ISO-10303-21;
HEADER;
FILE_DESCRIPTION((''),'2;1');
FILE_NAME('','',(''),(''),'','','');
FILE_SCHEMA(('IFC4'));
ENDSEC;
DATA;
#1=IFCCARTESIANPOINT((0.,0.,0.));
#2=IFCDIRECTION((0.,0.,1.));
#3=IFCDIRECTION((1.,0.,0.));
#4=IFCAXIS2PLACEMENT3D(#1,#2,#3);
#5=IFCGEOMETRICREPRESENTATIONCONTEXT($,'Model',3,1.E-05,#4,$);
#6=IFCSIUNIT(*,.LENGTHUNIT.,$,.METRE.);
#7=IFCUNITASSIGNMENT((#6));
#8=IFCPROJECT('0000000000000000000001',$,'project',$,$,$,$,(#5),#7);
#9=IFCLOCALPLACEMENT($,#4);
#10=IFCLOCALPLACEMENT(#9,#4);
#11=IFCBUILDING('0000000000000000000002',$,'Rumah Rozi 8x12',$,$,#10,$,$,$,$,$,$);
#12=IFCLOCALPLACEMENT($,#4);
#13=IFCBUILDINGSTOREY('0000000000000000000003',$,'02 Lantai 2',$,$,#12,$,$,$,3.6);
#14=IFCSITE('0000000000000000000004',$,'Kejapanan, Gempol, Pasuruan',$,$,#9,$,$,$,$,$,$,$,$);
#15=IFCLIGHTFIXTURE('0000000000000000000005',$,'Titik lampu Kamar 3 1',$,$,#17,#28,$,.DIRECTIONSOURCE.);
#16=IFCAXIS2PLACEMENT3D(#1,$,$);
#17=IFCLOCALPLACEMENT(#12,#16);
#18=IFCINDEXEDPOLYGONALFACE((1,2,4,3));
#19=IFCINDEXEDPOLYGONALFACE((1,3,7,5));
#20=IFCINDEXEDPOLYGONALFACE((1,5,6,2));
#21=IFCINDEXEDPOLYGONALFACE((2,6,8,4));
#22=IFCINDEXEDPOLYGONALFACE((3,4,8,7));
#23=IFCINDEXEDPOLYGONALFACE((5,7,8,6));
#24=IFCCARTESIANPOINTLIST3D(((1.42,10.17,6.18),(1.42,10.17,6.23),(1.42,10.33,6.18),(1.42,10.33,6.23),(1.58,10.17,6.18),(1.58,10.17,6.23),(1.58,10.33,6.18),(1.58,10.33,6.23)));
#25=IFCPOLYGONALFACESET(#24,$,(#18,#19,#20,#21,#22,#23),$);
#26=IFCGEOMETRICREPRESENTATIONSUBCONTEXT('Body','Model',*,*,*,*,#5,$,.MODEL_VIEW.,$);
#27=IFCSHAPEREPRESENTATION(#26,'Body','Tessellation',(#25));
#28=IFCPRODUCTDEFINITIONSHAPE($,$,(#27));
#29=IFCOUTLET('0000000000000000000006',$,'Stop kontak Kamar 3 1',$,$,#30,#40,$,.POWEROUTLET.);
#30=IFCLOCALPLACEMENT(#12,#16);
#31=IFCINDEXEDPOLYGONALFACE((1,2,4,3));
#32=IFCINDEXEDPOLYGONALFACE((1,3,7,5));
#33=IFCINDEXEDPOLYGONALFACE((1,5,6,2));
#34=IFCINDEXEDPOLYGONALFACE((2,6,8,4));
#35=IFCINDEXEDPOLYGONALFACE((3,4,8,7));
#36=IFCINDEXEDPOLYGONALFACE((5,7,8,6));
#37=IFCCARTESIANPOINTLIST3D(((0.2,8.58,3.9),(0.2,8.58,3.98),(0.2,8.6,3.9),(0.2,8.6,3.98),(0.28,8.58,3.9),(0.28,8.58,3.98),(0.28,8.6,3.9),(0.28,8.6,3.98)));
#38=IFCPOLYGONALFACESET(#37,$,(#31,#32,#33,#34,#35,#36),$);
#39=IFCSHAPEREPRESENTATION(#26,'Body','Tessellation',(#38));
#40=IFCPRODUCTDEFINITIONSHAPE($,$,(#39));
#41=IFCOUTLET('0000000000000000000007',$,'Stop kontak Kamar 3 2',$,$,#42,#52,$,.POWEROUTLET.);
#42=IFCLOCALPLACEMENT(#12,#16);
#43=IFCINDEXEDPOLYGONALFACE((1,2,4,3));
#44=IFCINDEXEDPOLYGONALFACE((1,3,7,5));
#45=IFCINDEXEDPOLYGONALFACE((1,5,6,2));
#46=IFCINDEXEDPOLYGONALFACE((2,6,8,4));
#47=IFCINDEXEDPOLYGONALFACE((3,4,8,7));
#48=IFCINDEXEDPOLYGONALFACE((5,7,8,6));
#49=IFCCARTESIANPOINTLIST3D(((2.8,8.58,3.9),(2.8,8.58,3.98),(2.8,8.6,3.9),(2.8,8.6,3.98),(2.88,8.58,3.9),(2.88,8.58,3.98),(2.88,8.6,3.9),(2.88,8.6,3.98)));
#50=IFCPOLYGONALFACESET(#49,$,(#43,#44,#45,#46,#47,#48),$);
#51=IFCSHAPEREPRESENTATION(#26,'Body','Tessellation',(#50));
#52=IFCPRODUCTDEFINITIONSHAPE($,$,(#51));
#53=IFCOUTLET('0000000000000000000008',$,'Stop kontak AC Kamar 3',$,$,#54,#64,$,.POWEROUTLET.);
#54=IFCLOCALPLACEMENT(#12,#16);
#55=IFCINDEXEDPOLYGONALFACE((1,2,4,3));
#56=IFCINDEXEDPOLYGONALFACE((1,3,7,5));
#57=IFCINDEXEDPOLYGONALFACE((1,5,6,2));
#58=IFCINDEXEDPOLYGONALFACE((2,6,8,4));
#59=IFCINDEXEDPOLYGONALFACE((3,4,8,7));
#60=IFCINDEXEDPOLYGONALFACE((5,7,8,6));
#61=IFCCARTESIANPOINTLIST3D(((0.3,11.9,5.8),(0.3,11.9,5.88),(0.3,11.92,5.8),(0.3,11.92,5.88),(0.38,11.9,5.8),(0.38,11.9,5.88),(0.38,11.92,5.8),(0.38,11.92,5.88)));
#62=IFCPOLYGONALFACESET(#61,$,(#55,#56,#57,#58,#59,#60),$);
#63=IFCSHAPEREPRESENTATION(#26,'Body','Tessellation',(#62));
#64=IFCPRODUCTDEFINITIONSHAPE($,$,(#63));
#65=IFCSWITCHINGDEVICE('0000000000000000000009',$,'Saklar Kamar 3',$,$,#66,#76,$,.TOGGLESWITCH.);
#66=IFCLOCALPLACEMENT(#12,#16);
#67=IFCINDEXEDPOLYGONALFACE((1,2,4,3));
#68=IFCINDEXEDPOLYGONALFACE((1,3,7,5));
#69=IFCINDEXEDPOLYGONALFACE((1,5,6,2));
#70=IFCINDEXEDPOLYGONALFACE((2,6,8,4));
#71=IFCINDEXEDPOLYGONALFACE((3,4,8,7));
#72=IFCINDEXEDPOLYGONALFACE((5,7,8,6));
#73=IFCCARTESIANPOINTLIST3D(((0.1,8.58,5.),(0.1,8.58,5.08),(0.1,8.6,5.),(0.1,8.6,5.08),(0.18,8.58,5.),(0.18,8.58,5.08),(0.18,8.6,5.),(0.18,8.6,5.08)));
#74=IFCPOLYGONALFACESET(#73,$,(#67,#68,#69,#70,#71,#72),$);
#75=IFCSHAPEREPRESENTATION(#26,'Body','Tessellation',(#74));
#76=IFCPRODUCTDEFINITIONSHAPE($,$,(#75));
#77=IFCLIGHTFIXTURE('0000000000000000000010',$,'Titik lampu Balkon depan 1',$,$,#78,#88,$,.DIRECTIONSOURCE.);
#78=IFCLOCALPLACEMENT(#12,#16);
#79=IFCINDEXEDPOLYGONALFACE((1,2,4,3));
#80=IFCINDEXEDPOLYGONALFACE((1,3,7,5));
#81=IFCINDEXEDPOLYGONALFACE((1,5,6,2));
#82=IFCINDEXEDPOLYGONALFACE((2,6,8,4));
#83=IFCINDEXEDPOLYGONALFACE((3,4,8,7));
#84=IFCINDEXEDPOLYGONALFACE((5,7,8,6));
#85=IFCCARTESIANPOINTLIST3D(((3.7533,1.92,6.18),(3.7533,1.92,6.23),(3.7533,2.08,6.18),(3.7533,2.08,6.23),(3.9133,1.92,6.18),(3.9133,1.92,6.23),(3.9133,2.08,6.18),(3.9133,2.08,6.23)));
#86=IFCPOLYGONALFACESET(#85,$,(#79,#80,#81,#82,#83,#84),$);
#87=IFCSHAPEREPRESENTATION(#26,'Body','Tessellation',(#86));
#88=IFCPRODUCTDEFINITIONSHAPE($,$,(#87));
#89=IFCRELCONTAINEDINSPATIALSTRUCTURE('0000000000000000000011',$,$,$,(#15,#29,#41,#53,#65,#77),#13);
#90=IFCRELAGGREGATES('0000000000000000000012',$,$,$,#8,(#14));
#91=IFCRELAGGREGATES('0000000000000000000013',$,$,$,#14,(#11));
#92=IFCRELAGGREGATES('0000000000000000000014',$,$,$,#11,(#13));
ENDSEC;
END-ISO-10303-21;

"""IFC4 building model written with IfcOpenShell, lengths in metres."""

from ifc_helpers import new_model, si_unit, frame, origin_with_axes, place, context, subcontext, project, spatial, line, indexed_curve, outline, extrude, element, save


model = new_model("IFC4")

# Units and contexts
model_context = context("Model", 3, precision=1e-05, world=origin_with_axes())
body_context = subcontext(model_context, "Body", "Model", "MODEL_VIEW")
ifc_project = project(units=[si_unit("LENGTHUNIT", "METRE")], contexts=[model_context])

# Site, building, storey
site_placement = place(None, origin_with_axes())
site = spatial("IfcSite", under=ifc_project, at=site_placement, Name="Kejapanan, Gempol, Pasuruan")
building_placement = place(site_placement, origin_with_axes())
building = spatial("IfcBuilding", under=site, at=building_placement, Name="Rumah Rozi 8x12")
storey_placement = place(None, origin_with_axes())
storey = spatial("IfcBuildingStorey", under=building, at=storey_placement, Name="02 Lantai 2", Elevation=3.6)

# Light fixture
light_fixture_1_placement = place(storey_placement, origin_with_axes())
element("IfcLightFixture", 1, at=light_fixture_1_placement, inside=storey, Name="Titik lampu Kamar 3 1", PredefinedType="DIRECTIONSOURCE", context=body_context, shape_type="SweptSolid", body=[
    extrude(outline(indexed_curve([(1.42, 10.17), (1.58, 10.17), (1.58, 10.33), (1.42, 10.33)], segments=[line(1, 2, 3, 4, 1)])), frame((0.0, 0.0, 6.18), z_axis=(0.0, 0.0, 1.0), x_axis=(1.0, 0.0, 0.0)), (0.0, 0.0, 1.0), 0.05),
])

# Outlets
outlet_1_placement = place(storey_placement, origin_with_axes())
element("IfcOutlet", 2, at=outlet_1_placement, inside=storey, Name="Stop kontak Kamar 3 1", PredefinedType="POWEROUTLET", context=body_context, shape_type="SweptSolid", body=[
    extrude(outline(indexed_curve([(0.2, 8.58), (0.28, 8.58), (0.28, 8.6), (0.2, 8.6)], segments=[line(1, 2, 3, 4, 1)])), frame((0.0, 0.0, 3.9), z_axis=(0.0, 0.0, 1.0), x_axis=(1.0, 0.0, 0.0)), (0.0, 0.0, 1.0), 0.08),
])
outlet_2_placement = place(storey_placement, origin_with_axes())
element("IfcOutlet", 3, at=outlet_2_placement, inside=storey, Name="Stop kontak Kamar 3 2", PredefinedType="POWEROUTLET", context=body_context, shape_type="SweptSolid", body=[
    extrude(outline(indexed_curve([(2.8, 8.58), (2.88, 8.58), (2.88, 8.6), (2.8, 8.6)], segments=[line(1, 2, 3, 4, 1)])), frame((0.0, 0.0, 3.9), z_axis=(0.0, 0.0, 1.0), x_axis=(1.0, 0.0, 0.0)), (0.0, 0.0, 1.0), 0.08),
])
outlet_3_placement = place(storey_placement, origin_with_axes())
element("IfcOutlet", 4, at=outlet_3_placement, inside=storey, Name="Stop kontak AC Kamar 3", PredefinedType="POWEROUTLET", context=body_context, shape_type="SweptSolid", body=[
    extrude(outline(indexed_curve([(0.3, 11.9), (0.38, 11.9), (0.38, 11.92), (0.3, 11.92)], segments=[line(1, 2, 3, 4, 1)])), frame((0.0, 0.0, 5.8), z_axis=(0.0, 0.0, 1.0), x_axis=(1.0, 0.0, 0.0)), (0.0, 0.0, 1.0), 0.08),
])

# Switching device
switching_device_1_placement = place(storey_placement, origin_with_axes())
element("IfcSwitchingDevice", 5, at=switching_device_1_placement, inside=storey, Name="Saklar Kamar 3", PredefinedType="TOGGLESWITCH", context=body_context, shape_type="SweptSolid", body=[
    extrude(outline(indexed_curve([(0.1, 8.58), (0.18, 8.58), (0.18, 8.6), (0.1, 8.6)], segments=[line(1, 2, 3, 4, 1)])), frame((0.0, 0.0, 5.0), z_axis=(0.0, 0.0, 1.0), x_axis=(1.0, 0.0, 0.0)), (0.0, 0.0, 1.0), 0.08),
])

# Light fixture
light_fixture_2_placement = place(storey_placement, origin_with_axes())
element("IfcLightFixture", 6, at=light_fixture_2_placement, inside=storey, Name="Titik lampu Balkon depan 1", PredefinedType="DIRECTIONSOURCE", context=body_context, shape_type="SweptSolid", body=[
    extrude(outline(indexed_curve([(3.7533, 1.92), (3.9133, 1.92), (3.9133, 2.08), (3.7533, 2.08)], segments=[line(1, 2, 3, 4, 1)])), frame((0.0, 0.0, 6.18), z_axis=(0.0, 0.0, 1.0), x_axis=(1.0, 0.0, 0.0)), (0.0, 0.0, 1.0), 0.05),
])

save(model, "model.ifc")
